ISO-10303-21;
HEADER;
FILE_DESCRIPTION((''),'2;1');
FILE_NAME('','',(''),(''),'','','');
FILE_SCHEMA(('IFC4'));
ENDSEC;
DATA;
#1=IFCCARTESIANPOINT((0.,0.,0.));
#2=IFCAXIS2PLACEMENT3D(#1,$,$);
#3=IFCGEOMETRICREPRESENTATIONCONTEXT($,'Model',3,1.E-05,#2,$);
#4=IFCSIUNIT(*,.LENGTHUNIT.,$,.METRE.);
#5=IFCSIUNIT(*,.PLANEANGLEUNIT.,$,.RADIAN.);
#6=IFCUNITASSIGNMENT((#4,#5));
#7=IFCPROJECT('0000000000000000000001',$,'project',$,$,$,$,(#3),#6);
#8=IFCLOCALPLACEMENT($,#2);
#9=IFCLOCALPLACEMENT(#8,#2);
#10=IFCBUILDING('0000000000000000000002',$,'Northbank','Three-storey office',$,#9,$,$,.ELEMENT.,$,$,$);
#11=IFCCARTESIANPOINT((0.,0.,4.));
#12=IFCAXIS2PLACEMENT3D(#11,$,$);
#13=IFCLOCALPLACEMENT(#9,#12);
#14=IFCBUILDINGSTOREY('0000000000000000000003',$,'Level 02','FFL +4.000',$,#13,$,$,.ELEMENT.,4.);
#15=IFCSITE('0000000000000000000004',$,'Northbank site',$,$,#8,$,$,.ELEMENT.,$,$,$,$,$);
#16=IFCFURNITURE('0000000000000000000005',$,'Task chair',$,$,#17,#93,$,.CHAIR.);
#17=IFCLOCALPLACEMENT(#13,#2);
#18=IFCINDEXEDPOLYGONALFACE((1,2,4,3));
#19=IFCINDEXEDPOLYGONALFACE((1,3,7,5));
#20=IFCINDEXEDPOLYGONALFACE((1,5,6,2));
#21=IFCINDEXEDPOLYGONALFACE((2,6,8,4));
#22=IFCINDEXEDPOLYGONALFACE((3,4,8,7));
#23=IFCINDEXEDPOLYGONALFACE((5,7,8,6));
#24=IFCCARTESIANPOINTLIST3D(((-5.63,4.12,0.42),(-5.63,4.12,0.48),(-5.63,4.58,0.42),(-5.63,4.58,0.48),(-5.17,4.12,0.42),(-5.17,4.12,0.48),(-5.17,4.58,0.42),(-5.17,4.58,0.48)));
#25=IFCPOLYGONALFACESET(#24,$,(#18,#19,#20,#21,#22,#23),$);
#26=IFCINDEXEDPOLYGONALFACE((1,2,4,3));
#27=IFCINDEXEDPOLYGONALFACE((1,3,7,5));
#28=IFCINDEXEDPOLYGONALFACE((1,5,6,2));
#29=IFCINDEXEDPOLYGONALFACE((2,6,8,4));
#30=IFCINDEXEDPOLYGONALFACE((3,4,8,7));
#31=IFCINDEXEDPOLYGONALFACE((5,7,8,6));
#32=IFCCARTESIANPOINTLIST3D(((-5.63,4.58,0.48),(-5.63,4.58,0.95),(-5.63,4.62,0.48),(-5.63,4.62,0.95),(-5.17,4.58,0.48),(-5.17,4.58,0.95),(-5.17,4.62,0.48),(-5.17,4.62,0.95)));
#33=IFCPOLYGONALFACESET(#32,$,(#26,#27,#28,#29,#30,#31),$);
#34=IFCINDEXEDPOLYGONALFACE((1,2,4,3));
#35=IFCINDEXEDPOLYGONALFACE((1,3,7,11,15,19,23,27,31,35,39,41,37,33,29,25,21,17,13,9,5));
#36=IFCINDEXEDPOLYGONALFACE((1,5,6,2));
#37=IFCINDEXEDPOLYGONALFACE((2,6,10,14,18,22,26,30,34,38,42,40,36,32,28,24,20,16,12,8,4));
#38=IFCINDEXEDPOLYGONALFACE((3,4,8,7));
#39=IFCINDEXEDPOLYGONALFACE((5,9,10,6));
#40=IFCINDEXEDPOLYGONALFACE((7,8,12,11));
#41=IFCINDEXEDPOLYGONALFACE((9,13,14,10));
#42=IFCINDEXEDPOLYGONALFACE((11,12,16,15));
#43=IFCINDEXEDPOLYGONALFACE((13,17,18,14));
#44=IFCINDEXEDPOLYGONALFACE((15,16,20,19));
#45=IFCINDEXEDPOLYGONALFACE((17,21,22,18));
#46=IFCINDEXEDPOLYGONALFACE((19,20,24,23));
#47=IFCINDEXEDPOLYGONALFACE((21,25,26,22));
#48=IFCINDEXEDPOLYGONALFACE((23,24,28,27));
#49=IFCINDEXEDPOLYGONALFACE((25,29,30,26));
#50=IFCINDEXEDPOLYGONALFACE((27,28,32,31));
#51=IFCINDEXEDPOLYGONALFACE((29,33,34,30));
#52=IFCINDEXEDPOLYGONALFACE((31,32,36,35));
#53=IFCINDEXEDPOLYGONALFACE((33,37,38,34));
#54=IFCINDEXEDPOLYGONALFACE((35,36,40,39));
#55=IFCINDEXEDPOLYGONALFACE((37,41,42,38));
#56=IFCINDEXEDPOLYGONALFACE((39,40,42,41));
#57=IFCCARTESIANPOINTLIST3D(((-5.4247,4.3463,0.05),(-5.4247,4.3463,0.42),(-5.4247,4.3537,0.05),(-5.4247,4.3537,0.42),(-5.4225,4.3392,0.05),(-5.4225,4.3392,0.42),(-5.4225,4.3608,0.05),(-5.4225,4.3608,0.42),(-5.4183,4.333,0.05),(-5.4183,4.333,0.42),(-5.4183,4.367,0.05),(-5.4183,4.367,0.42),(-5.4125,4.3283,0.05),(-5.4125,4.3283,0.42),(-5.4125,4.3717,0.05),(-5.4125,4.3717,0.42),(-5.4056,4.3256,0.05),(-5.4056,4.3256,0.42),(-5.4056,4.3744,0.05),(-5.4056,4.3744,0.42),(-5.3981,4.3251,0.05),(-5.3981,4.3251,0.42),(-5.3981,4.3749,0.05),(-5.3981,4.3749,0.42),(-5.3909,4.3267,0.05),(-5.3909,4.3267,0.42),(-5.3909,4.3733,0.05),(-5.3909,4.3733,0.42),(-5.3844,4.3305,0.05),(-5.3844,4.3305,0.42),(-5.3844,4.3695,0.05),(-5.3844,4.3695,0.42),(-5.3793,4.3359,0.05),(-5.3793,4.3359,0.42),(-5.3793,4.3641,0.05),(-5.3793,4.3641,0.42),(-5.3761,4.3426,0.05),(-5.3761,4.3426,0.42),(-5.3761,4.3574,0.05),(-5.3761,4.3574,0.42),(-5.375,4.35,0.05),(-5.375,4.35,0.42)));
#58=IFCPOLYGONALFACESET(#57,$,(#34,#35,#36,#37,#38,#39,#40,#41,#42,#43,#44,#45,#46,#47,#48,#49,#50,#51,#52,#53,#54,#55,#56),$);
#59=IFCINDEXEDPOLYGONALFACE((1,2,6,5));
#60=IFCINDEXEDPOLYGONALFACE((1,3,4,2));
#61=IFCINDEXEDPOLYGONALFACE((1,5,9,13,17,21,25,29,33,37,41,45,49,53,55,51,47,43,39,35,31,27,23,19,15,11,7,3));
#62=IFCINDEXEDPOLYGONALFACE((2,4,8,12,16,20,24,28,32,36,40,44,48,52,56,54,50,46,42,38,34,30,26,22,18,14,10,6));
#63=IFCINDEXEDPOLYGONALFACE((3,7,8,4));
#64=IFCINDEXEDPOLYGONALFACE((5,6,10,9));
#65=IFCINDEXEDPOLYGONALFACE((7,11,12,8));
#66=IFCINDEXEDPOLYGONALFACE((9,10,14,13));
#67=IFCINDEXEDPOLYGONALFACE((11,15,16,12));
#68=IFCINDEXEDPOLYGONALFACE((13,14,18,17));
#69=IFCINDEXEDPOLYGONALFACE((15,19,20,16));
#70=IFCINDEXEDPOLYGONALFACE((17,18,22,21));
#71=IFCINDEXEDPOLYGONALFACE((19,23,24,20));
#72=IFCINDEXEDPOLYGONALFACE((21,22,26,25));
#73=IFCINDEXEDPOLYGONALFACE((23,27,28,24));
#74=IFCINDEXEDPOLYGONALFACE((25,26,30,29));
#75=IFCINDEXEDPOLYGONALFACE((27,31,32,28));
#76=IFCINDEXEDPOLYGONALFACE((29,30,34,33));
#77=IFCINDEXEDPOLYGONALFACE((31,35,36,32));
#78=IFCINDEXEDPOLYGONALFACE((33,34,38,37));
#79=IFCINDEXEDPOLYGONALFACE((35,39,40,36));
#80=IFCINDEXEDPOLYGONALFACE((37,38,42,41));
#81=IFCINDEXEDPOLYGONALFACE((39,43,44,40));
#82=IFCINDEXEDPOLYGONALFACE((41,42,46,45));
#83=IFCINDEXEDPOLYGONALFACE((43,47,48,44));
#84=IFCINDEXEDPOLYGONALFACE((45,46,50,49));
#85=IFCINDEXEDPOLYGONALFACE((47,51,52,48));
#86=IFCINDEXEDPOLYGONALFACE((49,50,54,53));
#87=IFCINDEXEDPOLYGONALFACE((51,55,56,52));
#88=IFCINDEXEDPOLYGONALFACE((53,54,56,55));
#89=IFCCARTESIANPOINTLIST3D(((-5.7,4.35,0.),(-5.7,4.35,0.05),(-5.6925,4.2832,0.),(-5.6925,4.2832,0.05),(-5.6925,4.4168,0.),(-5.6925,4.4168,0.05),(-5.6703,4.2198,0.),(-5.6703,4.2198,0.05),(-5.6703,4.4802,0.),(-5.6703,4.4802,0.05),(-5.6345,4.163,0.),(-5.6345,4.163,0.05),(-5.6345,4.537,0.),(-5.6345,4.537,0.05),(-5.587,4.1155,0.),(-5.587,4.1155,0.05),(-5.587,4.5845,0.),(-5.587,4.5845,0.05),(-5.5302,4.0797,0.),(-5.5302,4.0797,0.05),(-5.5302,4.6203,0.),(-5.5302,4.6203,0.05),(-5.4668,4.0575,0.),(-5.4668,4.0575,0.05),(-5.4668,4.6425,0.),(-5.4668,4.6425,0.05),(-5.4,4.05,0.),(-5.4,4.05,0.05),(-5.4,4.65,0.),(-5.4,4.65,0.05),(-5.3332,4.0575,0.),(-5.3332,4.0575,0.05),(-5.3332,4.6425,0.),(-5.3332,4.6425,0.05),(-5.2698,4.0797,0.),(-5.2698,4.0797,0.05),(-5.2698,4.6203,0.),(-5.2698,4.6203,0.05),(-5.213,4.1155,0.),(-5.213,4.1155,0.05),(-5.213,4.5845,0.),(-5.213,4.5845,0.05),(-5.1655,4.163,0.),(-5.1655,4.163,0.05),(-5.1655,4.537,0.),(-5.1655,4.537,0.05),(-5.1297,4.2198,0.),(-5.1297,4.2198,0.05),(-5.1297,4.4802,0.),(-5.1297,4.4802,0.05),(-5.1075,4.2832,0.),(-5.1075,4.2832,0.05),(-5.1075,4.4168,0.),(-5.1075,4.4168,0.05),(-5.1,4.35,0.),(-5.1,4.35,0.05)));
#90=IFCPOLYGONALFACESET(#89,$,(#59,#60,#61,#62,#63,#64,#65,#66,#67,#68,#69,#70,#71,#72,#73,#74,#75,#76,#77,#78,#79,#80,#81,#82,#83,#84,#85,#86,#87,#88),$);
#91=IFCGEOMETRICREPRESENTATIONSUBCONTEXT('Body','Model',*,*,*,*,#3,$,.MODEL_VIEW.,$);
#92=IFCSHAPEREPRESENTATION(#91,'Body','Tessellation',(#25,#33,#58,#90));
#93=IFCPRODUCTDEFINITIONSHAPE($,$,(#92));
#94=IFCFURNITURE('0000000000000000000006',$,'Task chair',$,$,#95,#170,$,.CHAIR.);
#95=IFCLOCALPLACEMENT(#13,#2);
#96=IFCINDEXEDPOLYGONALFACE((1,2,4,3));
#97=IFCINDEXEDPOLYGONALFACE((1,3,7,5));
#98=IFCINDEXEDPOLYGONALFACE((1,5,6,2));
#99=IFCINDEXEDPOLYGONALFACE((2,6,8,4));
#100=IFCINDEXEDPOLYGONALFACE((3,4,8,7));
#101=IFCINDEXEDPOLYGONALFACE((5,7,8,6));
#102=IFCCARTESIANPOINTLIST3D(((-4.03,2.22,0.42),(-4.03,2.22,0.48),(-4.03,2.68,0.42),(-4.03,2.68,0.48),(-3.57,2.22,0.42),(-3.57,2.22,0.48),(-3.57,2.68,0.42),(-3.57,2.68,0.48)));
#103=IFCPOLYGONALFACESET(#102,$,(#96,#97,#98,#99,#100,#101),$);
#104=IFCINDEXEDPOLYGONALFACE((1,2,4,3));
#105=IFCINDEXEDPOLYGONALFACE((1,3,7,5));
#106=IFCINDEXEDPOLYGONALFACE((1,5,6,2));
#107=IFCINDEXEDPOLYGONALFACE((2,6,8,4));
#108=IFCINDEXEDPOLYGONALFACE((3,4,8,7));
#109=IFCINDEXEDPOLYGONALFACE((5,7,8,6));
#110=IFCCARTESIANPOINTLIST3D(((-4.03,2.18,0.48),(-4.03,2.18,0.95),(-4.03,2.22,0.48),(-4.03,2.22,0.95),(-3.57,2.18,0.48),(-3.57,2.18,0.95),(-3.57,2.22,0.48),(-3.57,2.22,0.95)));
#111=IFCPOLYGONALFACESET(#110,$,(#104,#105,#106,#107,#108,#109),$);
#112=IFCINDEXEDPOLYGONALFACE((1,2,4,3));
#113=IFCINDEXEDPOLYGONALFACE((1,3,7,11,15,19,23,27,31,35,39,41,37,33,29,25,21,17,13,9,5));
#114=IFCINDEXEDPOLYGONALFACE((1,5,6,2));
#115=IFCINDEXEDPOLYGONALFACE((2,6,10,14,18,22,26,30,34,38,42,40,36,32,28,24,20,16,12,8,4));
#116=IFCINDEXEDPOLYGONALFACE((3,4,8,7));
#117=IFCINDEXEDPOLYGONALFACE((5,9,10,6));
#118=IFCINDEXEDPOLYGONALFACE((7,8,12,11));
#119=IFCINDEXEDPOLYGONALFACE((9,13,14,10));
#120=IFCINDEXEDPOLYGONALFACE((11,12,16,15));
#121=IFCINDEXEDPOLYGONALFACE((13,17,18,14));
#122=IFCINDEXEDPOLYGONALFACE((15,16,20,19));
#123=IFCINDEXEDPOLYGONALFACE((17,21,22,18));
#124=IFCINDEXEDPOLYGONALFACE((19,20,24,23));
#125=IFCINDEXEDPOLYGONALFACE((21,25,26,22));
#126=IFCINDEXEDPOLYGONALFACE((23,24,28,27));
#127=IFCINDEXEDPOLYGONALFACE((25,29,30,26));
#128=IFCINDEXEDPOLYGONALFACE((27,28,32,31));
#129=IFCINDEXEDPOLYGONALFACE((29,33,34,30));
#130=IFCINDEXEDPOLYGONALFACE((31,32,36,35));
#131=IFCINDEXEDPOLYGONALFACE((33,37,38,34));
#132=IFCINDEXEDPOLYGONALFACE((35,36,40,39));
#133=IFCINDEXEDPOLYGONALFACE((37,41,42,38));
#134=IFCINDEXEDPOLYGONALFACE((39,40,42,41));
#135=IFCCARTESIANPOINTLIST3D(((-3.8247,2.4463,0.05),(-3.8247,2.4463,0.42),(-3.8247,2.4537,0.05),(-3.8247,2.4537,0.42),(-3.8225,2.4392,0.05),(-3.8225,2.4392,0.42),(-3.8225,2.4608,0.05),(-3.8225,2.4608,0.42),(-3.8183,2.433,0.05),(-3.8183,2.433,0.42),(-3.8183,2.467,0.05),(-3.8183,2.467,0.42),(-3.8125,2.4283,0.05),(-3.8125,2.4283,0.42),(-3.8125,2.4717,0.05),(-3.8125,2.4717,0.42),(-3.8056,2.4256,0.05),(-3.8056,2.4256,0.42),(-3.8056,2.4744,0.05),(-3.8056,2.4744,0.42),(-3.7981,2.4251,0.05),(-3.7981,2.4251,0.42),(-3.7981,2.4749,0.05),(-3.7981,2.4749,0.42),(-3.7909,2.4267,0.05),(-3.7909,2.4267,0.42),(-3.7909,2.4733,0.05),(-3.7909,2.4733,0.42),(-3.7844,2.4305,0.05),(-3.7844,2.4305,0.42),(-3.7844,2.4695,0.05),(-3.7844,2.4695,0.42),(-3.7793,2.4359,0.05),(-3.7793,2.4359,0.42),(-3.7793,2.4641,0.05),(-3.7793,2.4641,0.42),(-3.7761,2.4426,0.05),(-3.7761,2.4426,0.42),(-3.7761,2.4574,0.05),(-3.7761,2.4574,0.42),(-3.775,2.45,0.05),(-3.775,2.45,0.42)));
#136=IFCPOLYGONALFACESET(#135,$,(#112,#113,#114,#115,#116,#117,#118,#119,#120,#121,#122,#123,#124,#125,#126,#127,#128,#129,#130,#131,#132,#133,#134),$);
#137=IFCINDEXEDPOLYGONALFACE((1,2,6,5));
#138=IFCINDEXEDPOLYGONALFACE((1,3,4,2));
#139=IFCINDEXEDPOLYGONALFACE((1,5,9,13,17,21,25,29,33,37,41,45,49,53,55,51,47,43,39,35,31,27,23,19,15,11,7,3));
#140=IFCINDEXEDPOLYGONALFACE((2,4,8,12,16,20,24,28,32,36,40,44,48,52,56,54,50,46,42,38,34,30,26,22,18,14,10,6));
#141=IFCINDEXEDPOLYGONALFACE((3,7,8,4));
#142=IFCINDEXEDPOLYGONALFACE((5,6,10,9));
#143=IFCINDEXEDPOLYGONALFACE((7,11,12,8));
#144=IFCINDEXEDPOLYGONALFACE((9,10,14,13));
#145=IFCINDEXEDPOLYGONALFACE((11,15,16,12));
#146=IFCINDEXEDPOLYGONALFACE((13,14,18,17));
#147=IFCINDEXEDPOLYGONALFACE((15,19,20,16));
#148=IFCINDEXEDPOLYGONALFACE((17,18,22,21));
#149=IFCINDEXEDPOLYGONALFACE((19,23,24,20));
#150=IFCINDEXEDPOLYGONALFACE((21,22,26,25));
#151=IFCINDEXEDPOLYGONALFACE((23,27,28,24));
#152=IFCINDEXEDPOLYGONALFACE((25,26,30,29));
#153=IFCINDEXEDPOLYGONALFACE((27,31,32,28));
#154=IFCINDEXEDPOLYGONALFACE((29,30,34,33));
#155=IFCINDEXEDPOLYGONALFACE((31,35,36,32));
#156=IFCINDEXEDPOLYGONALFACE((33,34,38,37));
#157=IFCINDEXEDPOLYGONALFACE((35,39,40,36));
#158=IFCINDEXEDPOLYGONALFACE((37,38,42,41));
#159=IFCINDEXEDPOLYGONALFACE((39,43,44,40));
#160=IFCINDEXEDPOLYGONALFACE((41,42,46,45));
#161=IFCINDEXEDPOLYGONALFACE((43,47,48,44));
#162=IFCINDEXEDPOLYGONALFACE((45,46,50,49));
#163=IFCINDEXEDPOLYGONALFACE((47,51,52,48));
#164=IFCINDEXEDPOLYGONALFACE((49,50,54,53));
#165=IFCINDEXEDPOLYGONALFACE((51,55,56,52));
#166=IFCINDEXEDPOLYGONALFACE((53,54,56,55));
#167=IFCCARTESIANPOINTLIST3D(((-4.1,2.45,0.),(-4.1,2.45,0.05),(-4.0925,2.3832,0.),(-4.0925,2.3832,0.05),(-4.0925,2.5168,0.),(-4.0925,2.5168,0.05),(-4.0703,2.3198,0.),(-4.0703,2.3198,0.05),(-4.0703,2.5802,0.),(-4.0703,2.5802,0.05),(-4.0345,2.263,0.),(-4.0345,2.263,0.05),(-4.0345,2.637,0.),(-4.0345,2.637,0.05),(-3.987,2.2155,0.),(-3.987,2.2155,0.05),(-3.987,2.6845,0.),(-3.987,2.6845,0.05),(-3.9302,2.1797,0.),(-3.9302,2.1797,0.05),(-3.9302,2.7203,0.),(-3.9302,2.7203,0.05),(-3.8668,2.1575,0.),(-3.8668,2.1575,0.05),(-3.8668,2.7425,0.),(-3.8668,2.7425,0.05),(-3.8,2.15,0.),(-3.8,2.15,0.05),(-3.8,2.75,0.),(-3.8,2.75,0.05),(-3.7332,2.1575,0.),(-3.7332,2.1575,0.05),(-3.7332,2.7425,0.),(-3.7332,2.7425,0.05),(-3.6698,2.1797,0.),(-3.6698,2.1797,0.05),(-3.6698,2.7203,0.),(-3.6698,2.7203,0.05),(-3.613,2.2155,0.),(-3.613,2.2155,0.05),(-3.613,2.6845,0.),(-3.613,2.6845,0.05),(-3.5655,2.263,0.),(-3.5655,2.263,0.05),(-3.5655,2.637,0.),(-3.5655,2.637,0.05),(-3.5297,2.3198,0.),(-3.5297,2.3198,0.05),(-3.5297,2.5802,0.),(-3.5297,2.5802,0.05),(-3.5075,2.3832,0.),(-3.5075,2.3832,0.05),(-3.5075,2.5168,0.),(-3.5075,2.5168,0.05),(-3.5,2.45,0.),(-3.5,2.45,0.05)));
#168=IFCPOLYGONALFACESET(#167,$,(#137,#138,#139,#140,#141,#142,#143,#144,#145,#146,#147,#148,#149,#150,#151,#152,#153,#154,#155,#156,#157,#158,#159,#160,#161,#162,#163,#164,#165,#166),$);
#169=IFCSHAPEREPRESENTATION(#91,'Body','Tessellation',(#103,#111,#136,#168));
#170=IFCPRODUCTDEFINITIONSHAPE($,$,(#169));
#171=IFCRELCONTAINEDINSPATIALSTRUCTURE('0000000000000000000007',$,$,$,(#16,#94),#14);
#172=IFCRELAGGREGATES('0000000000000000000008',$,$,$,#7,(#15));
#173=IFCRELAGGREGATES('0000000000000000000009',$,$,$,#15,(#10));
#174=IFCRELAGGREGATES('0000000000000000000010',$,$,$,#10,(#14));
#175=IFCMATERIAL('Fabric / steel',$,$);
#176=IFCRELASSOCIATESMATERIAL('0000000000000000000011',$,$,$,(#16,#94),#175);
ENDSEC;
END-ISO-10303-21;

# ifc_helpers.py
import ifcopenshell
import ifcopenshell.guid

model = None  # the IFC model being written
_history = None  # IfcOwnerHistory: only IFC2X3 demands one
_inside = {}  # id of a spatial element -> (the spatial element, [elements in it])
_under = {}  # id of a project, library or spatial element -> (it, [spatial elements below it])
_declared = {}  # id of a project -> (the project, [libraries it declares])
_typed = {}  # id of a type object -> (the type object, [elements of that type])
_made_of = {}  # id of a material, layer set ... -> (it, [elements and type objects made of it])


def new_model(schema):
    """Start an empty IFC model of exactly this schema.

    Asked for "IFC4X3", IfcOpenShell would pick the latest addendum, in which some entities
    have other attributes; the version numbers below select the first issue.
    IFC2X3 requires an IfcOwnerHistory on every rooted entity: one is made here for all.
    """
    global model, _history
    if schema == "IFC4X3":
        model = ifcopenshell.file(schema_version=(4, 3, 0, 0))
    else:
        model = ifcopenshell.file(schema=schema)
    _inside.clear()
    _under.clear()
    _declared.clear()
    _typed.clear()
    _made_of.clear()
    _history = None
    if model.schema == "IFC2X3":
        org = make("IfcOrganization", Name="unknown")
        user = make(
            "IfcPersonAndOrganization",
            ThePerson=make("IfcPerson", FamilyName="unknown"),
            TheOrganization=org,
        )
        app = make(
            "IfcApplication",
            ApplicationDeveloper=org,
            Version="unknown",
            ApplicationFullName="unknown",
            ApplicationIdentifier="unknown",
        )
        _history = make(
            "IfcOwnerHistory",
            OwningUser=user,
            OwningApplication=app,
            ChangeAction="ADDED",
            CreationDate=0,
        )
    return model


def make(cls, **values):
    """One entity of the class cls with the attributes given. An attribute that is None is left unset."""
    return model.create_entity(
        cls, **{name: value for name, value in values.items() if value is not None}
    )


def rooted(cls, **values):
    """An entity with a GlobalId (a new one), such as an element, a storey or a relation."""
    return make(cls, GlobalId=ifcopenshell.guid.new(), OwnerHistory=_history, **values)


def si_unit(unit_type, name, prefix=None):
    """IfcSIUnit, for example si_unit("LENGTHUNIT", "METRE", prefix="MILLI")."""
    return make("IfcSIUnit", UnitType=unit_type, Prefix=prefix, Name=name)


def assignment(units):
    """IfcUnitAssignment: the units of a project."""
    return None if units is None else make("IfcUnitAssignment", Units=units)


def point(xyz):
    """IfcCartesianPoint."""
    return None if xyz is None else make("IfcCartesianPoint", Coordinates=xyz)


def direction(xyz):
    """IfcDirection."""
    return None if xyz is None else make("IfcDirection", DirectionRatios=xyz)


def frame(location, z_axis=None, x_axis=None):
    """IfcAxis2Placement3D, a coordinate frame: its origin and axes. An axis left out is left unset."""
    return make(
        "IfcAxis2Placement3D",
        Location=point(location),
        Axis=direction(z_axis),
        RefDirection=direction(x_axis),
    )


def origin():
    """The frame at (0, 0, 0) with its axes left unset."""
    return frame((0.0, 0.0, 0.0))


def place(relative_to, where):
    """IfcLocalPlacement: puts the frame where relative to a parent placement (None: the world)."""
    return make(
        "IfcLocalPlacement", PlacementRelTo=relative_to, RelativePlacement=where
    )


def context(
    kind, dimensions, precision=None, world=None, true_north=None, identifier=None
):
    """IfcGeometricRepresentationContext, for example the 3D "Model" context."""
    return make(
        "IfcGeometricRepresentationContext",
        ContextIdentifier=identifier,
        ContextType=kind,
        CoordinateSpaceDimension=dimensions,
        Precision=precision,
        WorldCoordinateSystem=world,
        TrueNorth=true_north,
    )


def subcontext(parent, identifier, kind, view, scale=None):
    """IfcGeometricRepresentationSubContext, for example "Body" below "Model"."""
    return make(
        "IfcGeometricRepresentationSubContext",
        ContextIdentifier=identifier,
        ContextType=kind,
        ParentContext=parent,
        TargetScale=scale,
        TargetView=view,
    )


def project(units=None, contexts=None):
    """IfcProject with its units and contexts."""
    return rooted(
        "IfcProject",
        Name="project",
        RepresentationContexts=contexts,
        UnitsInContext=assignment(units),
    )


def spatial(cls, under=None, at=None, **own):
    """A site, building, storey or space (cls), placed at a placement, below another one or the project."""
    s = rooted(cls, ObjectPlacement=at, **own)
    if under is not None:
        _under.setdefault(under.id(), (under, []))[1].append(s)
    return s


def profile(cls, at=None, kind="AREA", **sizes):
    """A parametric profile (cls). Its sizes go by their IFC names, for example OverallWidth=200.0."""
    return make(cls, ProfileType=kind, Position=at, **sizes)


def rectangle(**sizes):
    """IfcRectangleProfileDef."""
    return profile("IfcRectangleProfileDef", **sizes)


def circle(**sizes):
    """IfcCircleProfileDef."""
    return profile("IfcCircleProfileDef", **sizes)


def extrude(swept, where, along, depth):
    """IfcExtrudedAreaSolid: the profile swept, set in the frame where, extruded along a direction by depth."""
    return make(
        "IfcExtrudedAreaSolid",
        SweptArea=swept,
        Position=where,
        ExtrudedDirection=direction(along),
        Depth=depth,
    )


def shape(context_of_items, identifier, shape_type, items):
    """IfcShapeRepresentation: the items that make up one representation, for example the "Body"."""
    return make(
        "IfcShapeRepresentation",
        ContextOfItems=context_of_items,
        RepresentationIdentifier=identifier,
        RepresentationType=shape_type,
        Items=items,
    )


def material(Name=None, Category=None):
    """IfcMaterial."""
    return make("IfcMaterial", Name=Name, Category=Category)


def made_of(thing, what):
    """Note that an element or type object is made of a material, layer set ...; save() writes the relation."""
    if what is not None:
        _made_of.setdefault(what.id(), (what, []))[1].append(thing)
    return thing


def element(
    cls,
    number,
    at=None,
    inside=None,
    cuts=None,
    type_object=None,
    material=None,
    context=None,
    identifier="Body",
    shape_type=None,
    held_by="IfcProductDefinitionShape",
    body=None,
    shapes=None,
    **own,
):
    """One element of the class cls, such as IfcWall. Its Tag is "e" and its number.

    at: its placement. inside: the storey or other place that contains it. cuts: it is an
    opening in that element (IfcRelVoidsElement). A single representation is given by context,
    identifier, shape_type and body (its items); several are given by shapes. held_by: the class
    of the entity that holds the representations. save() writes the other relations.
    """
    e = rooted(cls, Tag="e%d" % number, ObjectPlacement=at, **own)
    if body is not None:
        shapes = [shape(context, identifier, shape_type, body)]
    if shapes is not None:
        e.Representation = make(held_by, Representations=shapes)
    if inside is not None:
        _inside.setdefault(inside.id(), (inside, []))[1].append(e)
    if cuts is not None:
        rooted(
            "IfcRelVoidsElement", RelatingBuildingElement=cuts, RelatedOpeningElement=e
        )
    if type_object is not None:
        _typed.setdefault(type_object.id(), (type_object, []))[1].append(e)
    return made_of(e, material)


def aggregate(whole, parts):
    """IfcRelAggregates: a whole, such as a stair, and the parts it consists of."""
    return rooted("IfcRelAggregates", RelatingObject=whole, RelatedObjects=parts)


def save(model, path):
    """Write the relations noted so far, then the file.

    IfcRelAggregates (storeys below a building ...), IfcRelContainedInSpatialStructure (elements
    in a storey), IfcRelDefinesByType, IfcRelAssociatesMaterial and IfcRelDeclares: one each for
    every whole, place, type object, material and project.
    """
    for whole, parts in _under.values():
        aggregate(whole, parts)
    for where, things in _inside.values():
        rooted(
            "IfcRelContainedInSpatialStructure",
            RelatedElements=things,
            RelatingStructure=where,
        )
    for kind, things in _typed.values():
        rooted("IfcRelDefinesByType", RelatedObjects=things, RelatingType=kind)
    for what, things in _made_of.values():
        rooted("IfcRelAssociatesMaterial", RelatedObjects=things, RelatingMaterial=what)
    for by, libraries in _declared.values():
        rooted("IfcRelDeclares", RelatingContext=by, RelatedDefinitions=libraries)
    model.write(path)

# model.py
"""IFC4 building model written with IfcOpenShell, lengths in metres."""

from ifc_helpers import new_model, si_unit, frame, origin, place, context, subcontext, project, spatial, rectangle, circle, extrude, material, element, save


model = new_model("IFC4")

# Units and contexts
model_context = context("Model", 3, precision=1e-05, world=origin())
body_context = subcontext(model_context, "Body", "Model", "MODEL_VIEW")
ifc_project = project(units=[si_unit("LENGTHUNIT", "METRE"), si_unit("PLANEANGLEUNIT", "RADIAN")], contexts=[model_context])

# Site, building, storey
site_placement = place(None, origin())
site = spatial("IfcSite", under=ifc_project, at=site_placement, Name="Northbank site", CompositionType="ELEMENT")
building_placement = place(site_placement, origin())
building = spatial("IfcBuilding", under=site, at=building_placement, Name="Northbank", Description="Three-storey office", CompositionType="ELEMENT")
storey_placement = place(building_placement, frame((0.0, 0.0, 4.0)))
storey = spatial("IfcBuildingStorey", under=building, at=storey_placement, Name="Level 02", Description="FFL +4.000", CompositionType="ELEMENT", Elevation=4.0)

# Furniture
ifc_material_1 = material(Name="Fabric / steel")
furniture_1_placement = place(storey_placement, frame((0.0, 0.0, -4.0)))
element("IfcFurniture", 1, at=furniture_1_placement, inside=storey, material=ifc_material_1, Name="Task chair", PredefinedType="CHAIR", context=body_context, shape_type="SweptSolid", body=[
    extrude(rectangle(XDim=0.46, YDim=0.46), frame((-5.4, 4.35, 4.42)), (0.0, 0.0, 1.0), 0.06),
    extrude(rectangle(XDim=0.46, YDim=0.04), frame((-5.4, 4.6, 4.48)), (0.0, 0.0, 1.0), 0.47),
    extrude(circle(Radius=0.025), frame((-5.4, 4.35, 4.05), z_axis=(0.0, 0.0, 1.0), x_axis=(1.0, 0.0, 0.0)), (0.0, 0.0, 1.0), 0.37),
    extrude(circle(Radius=0.3), frame((-5.4, 4.35, 4.0), z_axis=(0.0, 0.0, 1.0), x_axis=(1.0, 0.0, 0.0)), (0.0, 0.0, 1.0), 0.05),
])
furniture_2_placement = place(storey_placement, frame((0.0, 0.0, -4.0)))
element("IfcFurniture", 2, at=furniture_2_placement, inside=storey, material=ifc_material_1, Name="Task chair", PredefinedType="CHAIR", context=body_context, shape_type="SweptSolid", body=[
    extrude(rectangle(XDim=0.46, YDim=0.46), frame((-3.8, 2.45, 4.42)), (0.0, 0.0, 1.0), 0.06),
    extrude(rectangle(XDim=0.46, YDim=0.04), frame((-3.8, 2.2, 4.48)), (0.0, 0.0, 1.0), 0.47),
    extrude(circle(Radius=0.025), frame((-3.8, 2.45, 4.05), z_axis=(0.0, 0.0, 1.0), x_axis=(1.0, 0.0, 0.0)), (0.0, 0.0, 1.0), 0.37),
    extrude(circle(Radius=0.3), frame((-3.8, 2.45, 4.0), z_axis=(0.0, 0.0, 1.0), x_axis=(1.0, 0.0, 0.0)), (0.0, 0.0, 1.0), 0.05),
])

save(model, "model.ifc")
